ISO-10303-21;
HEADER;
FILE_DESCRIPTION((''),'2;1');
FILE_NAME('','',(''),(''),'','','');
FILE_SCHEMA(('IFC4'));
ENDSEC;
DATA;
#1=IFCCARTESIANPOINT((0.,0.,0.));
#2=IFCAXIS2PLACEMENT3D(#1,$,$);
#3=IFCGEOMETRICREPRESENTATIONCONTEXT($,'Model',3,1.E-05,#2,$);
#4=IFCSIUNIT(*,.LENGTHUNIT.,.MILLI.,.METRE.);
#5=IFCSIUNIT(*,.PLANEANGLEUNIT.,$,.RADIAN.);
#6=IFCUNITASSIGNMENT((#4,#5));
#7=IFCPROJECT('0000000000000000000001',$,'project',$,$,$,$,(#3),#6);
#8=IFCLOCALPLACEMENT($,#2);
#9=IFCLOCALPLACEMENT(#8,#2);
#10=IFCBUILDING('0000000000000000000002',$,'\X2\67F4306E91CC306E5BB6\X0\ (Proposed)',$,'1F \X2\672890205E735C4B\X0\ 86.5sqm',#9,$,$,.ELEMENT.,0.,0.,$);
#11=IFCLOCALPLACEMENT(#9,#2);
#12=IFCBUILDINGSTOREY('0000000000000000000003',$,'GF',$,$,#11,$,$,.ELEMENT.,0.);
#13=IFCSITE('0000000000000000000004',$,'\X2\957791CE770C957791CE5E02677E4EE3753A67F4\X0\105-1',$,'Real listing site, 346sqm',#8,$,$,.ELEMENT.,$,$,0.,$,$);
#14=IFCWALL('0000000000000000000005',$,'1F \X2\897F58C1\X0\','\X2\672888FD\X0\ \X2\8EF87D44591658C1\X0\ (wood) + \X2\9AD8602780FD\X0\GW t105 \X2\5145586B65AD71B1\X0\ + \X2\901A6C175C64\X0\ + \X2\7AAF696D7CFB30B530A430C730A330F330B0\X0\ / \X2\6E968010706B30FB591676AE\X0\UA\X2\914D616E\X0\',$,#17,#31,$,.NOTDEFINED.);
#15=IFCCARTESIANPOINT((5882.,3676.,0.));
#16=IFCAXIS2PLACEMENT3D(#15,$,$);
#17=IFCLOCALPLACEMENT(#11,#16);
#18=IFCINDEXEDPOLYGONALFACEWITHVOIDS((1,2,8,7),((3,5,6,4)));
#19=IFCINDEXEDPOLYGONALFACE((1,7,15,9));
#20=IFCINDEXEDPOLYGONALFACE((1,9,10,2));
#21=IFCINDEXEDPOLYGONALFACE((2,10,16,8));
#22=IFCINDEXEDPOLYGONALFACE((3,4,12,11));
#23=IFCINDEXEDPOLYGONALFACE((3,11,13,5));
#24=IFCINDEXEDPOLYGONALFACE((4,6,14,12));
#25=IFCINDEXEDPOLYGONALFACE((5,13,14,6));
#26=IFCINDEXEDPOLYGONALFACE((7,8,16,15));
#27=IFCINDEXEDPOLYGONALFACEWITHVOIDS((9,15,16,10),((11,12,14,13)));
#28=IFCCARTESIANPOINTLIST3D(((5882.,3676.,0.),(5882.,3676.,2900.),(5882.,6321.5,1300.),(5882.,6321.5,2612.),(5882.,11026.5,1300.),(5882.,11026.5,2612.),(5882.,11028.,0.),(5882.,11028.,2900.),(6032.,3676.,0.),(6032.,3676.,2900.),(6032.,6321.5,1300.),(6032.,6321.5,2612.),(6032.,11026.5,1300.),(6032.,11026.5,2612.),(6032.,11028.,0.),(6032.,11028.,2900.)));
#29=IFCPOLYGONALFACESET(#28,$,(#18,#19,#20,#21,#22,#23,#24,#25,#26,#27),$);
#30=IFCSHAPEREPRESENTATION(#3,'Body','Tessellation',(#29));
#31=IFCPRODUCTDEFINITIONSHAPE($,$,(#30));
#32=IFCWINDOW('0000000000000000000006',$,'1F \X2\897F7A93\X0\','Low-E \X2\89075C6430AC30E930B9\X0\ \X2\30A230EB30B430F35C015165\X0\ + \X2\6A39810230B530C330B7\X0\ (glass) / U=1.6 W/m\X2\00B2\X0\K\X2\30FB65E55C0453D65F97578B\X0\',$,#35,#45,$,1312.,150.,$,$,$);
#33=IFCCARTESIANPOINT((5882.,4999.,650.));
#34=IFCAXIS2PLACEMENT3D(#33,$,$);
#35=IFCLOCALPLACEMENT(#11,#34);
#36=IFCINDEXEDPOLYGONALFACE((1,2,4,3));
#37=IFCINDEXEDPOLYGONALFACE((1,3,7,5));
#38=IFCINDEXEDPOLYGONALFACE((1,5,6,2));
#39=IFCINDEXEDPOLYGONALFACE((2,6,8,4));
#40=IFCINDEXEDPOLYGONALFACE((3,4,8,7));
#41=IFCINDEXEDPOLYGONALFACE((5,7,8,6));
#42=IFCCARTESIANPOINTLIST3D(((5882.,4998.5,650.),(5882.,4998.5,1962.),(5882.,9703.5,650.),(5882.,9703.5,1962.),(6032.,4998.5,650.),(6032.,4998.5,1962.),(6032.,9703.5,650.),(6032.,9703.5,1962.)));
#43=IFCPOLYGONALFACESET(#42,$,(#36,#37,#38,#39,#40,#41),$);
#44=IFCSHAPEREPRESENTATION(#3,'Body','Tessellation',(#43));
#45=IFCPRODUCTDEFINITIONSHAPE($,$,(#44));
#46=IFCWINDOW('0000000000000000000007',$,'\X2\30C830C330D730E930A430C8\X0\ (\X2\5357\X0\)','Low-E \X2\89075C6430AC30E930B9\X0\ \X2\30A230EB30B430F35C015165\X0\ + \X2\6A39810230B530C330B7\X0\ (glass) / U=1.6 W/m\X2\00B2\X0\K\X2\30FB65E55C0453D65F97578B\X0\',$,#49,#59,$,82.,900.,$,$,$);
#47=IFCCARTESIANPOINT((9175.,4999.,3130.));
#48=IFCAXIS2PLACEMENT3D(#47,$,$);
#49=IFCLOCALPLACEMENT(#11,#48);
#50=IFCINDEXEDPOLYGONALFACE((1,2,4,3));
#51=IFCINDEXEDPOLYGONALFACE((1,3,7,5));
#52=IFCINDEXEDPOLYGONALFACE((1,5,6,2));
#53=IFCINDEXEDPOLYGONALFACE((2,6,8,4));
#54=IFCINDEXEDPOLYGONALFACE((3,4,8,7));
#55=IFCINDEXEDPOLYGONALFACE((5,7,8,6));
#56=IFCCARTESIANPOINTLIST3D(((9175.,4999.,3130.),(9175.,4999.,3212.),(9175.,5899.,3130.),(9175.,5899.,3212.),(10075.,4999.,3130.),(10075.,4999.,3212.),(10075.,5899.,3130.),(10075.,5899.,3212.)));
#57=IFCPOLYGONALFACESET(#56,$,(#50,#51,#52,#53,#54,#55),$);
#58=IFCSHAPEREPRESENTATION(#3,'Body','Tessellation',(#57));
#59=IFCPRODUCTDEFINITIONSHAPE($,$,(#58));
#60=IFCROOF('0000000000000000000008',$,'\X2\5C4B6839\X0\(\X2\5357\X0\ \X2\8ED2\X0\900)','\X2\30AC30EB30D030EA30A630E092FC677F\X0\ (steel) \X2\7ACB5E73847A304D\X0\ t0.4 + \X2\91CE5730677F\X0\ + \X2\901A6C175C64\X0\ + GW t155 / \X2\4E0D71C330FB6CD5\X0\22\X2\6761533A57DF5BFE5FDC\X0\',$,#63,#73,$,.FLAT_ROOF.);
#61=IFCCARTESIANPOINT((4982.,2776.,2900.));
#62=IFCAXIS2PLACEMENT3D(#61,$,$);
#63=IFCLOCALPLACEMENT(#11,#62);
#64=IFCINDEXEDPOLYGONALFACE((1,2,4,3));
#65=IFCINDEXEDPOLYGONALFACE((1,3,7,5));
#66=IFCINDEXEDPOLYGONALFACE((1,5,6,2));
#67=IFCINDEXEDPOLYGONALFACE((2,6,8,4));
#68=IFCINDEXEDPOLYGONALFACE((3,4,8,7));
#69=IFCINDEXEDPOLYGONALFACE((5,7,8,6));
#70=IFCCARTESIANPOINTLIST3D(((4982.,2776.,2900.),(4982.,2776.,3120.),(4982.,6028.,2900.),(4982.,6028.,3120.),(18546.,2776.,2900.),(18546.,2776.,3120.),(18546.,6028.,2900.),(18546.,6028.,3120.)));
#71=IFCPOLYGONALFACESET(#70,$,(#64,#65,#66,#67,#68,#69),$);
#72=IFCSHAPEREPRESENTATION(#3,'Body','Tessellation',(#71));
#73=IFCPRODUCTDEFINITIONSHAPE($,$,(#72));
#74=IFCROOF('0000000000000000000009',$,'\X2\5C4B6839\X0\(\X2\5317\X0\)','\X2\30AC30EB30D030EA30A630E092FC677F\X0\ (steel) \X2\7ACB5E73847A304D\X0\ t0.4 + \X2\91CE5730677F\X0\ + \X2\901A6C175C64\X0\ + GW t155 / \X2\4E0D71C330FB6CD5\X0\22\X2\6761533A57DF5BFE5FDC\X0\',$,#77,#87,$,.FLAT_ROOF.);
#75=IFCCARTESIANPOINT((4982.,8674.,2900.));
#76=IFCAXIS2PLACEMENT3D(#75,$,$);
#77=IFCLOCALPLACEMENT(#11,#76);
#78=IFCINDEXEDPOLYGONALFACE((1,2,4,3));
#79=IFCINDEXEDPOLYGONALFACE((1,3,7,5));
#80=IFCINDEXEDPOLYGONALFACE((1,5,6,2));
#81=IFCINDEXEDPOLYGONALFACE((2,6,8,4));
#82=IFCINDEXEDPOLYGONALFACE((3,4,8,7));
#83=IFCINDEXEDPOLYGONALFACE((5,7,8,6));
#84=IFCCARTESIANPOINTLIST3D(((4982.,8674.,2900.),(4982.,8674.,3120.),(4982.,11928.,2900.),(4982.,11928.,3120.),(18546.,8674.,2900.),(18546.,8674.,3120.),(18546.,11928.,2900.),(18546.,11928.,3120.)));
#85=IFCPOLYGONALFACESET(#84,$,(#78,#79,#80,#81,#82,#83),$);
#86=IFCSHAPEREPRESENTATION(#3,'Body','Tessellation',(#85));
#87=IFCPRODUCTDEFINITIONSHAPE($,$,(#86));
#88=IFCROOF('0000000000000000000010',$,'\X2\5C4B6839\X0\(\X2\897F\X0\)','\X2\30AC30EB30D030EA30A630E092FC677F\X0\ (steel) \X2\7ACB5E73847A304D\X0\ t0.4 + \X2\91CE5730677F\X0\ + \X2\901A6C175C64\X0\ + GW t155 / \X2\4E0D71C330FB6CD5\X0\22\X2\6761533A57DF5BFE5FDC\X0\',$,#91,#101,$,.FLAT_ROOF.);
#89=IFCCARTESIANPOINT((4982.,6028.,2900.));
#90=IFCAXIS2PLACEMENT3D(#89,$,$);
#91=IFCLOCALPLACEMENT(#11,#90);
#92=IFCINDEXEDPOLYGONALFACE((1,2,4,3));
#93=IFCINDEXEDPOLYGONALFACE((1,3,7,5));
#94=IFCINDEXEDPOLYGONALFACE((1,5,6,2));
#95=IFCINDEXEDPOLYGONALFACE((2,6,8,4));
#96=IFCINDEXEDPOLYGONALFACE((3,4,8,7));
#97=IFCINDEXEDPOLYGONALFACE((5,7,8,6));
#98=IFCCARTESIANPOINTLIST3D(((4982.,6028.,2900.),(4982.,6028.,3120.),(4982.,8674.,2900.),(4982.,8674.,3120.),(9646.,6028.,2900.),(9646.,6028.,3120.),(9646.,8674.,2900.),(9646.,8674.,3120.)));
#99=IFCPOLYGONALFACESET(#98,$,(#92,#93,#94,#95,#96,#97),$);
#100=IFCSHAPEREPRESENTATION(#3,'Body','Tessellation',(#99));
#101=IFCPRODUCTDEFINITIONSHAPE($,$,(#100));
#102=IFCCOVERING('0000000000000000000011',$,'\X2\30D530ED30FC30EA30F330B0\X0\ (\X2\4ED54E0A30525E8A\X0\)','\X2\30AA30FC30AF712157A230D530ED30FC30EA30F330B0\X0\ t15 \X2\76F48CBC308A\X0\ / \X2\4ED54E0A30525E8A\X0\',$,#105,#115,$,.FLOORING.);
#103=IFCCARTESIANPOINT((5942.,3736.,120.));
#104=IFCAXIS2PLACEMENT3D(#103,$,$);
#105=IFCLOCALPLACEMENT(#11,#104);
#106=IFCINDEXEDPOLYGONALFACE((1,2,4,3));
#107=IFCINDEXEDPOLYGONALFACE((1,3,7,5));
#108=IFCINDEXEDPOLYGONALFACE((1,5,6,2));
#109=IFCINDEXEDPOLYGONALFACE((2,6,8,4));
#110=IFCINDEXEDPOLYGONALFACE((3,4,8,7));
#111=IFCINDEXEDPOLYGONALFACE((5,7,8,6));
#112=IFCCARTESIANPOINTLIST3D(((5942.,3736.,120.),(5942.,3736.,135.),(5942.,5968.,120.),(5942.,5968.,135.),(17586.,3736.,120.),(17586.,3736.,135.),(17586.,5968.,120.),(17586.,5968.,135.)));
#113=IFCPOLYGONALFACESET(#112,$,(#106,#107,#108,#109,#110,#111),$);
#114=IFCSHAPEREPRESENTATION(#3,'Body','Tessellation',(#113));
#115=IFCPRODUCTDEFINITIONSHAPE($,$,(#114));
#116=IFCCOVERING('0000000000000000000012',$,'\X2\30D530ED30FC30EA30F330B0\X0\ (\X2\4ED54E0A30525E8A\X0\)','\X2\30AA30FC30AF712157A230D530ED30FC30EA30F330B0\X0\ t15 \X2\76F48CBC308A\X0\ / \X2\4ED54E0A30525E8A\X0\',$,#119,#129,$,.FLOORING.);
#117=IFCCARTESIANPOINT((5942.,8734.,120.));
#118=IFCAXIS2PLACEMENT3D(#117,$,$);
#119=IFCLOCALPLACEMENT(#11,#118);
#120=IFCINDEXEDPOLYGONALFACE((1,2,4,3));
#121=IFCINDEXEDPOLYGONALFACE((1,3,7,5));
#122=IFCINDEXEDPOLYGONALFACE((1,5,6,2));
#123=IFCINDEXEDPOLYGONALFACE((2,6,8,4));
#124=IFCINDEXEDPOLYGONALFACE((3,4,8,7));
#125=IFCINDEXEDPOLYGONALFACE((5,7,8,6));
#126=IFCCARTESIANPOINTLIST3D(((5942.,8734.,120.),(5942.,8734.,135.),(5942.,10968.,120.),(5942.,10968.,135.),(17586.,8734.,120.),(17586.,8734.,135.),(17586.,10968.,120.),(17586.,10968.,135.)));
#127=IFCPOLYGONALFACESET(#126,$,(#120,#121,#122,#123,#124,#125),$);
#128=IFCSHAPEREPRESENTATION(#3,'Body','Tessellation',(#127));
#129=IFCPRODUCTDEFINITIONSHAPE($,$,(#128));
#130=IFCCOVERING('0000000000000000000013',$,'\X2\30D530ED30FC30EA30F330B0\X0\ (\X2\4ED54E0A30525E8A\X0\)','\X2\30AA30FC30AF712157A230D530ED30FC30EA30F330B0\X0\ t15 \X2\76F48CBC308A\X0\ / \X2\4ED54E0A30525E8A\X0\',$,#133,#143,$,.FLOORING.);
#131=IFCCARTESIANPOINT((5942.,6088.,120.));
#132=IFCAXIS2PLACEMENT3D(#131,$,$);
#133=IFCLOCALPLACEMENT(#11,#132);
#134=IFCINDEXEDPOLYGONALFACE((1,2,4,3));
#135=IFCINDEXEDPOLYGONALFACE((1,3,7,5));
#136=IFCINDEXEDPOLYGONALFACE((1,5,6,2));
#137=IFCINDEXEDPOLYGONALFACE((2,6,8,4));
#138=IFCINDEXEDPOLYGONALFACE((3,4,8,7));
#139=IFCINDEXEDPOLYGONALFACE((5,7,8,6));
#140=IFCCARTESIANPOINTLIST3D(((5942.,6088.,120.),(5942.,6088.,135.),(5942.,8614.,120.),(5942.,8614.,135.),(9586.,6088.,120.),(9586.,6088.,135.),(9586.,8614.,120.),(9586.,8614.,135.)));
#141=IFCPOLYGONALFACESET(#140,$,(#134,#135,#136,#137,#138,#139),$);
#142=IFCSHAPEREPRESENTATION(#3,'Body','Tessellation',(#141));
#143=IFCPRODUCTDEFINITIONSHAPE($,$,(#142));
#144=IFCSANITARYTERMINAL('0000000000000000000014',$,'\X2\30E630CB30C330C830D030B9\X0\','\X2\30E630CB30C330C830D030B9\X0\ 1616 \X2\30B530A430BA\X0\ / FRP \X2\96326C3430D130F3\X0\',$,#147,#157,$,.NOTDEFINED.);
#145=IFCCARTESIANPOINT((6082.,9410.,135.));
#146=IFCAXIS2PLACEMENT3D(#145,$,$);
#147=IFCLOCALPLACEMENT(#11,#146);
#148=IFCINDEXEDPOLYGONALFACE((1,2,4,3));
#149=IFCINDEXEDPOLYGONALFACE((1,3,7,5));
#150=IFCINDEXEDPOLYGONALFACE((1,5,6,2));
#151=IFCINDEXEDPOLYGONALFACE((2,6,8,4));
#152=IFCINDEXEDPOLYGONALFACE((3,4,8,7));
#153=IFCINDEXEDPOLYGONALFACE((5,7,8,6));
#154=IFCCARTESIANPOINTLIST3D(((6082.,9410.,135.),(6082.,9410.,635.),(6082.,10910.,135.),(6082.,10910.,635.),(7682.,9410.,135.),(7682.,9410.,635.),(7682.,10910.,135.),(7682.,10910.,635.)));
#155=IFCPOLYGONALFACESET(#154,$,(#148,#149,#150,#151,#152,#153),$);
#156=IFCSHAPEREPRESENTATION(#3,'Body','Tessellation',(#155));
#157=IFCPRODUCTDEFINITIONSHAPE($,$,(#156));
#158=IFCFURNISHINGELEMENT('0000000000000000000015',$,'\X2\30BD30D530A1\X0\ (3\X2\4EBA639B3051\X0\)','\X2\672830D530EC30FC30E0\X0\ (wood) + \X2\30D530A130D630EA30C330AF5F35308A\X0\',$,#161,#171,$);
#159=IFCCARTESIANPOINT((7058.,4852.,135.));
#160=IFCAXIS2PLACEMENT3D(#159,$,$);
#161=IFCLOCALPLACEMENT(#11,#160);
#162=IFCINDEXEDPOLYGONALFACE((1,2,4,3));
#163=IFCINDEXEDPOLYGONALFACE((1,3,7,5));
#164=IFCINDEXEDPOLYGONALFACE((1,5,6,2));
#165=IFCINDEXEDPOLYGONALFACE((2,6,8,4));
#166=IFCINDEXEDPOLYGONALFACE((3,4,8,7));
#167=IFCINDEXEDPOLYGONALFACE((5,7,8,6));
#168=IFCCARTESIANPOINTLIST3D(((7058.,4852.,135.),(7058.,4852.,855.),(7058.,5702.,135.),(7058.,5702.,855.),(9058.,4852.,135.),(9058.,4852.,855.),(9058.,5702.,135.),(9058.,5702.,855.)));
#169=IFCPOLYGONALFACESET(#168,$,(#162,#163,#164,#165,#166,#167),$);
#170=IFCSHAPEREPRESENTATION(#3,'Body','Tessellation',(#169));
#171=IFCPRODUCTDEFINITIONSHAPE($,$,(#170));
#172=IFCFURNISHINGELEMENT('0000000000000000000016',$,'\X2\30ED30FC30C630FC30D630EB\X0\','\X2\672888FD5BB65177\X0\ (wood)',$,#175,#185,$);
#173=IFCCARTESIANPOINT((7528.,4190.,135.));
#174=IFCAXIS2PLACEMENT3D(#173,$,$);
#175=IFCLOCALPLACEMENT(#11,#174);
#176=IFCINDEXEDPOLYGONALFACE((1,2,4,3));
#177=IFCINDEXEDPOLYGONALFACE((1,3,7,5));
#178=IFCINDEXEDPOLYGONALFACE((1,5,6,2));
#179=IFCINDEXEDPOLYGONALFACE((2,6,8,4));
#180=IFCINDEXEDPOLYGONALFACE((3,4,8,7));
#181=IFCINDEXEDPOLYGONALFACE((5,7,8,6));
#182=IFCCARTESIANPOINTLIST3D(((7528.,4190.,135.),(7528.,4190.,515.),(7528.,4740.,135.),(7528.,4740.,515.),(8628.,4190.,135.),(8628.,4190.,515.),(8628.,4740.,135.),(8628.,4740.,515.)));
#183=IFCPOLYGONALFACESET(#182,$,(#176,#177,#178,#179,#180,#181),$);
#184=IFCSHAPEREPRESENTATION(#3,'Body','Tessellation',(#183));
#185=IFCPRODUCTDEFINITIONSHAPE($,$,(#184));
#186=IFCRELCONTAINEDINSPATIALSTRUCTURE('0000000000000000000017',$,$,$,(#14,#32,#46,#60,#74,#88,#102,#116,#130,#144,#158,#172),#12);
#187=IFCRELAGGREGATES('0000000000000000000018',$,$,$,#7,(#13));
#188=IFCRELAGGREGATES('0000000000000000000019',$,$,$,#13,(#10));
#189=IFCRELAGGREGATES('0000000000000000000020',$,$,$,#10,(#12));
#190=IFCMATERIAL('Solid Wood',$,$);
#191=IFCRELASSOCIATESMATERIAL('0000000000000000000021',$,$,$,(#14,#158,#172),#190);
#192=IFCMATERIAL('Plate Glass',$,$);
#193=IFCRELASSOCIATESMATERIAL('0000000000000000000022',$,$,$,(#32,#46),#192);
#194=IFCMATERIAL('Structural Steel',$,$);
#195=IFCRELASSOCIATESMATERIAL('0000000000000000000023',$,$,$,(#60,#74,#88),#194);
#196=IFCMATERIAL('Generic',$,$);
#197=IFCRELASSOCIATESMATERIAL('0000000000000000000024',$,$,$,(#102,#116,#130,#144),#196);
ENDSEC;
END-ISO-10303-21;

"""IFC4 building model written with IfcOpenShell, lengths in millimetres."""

from ifc_helpers import new_model, si_unit, frame, frame_2d, origin, place, context, project, spatial, rectangle, extrude, material, element, fill, save


model = new_model("IFC4")

# Units and contexts
model_context = context("Model", 3, precision=1e-05, world=origin())
ifc_project = project(units=[si_unit("LENGTHUNIT", "METRE", prefix="MILLI"), si_unit("PLANEANGLEUNIT", "RADIAN")], contexts=[model_context])

# Site, building, storey
site_placement = place(None, origin())
site = spatial("IfcSite", under=ifc_project, at=site_placement, Name="長野県長野市松代町柴105-1", ObjectType="Real listing site, 346sqm", CompositionType="ELEMENT", RefElevation=0.0)
building_placement = place(site_placement, origin())
building = spatial("IfcBuilding", under=site, at=building_placement, Name="柴の里の家 (Proposed)", ObjectType="1F 木造平屋 86.5sqm", CompositionType="ELEMENT", ElevationOfRefHeight=0.0, ElevationOfTerrain=0.0)
storey_placement = place(building_placement, origin())
storey = spatial("IfcBuildingStorey", under=building, at=storey_placement, Name="GF", CompositionType="ELEMENT", Elevation=0.0)

# Shared definitions
ifc_material_1 = material(Name="Solid Wood")

# Shared definitions
ifc_material_2 = material(Name="Plate Glass")

# Wall, opening, window
wall_1_placement = place(storey_placement, frame((5882.0, 3676.0, 0.0)))
wall_1 = element("IfcWall", 1, at=wall_1_placement, inside=storey, material=ifc_material_1, Name="1F 西壁", Description="木製 軸組外壁 (wood) + 高性能GW t105 充填断熱 + 通気層 + 窯業系サイディング / 準耐火・外皮UA配慮", PredefinedType="NOTDEFINED", context=model_context, shape_type="SweptSolid", body=[
    extrude(rectangle(XDim=150.0, YDim=7352.0, at=frame_2d((75.0, 3676.0))), frame((5882.0, 3676.0, 0.0)), (0.0, 0.0, 1.0), 2900.0),
])
opening_1_placement = place(storey_placement, frame((5882.0, 4999.0, 650.0)))
opening_1 = element("IfcOpeningElement", 2, at=opening_1_placement, cuts=wall_1, PredefinedType="NOTDEFINED", context=model_context, shape_type="SweptSolid", body=[
    extrude(rectangle(XDim=150.0, YDim=4705.0, at=frame_2d((75.0, 2352.0))), frame((5882.0, 4999.0, 650.0)), (0.0, 0.0, 1.0), 1312.0),
])
window_1_placement = place(storey_placement, frame((5882.0, 4999.0, 650.0)))
window_1 = element("IfcWindow", 3, at=window_1_placement, inside=storey, material=ifc_material_2, Name="1F 西窓", Description="Low-E 複層ガラス アルゴン封入 + 樹脂サッシ (glass) / U=1.6 W/m²K・日射取得型", OverallHeight=1312.0, OverallWidth=150.0, context=model_context, shape_type="SweptSolid", body=[
    extrude(rectangle(XDim=150.0, YDim=4705.0, at=frame_2d((75.0, 2352.0))), frame((5882.0, 4999.0, 650.0)), (0.0, 0.0, 1.0), 1312.0),
])
fill(opening_1, window_1)

# Window
window_2_placement = place(storey_placement, frame((9175.0, 4999.0, 3130.0)))
element("IfcWindow", 4, at=window_2_placement, inside=storey, material=ifc_material_2, Name="トップライト (南)", Description="Low-E 複層ガラス アルゴン封入 + 樹脂サッシ (glass) / U=1.6 W/m²K・日射取得型", OverallHeight=82.0, OverallWidth=900.0, context=model_context, shape_type="SweptSolid", body=[
    extrude(rectangle(XDim=900.0, YDim=900.0, at=frame_2d((450.0, 450.0))), frame((9175.0, 4999.0, 3130.0)), (0.0, 0.0, 1.0), 82.0),
])

# Roofs
ifc_material_3 = material(Name="Structural Steel")
roof_1_placement = place(storey_placement, frame((4982.0, 2776.0, 2900.0)))
element("IfcRoof", 5, at=roof_1_placement, inside=storey, material=ifc_material_3, Name="屋根(南 軒900)", Description="ガルバリウム鋼板 (steel) 立平葺き t0.4 + 野地板 + 通気層 + GW t155 / 不燃・法22条区域対応", PredefinedType="FLAT_ROOF", context=model_context, shape_type="SweptSolid", body=[
    extrude(rectangle(XDim=13564.0, YDim=3252.0, at=frame_2d((6782.0, 1626.0))), frame((4982.0, 2776.0, 2900.0)), (0.0, 0.0, 1.0), 220.0),
])
roof_2_placement = place(storey_placement, frame((4982.0, 8674.0, 2900.0)))
element("IfcRoof", 6, at=roof_2_placement, inside=storey, material=ifc_material_3, Name="屋根(北)", Description="ガルバリウム鋼板 (steel) 立平葺き t0.4 + 野地板 + 通気層 + GW t155 / 不燃・法22条区域対応", PredefinedType="FLAT_ROOF", context=model_context, shape_type="SweptSolid", body=[
    extrude(rectangle(XDim=13564.0, YDim=3254.0, at=frame_2d((6782.0, 1627.0))), frame((4982.0, 8674.0, 2900.0)), (0.0, 0.0, 1.0), 220.0),
])
roof_3_placement = place(storey_placement, frame((4982.0, 6028.0, 2900.0)))
element("IfcRoof", 7, at=roof_3_placement, inside=storey, material=ifc_material_3, Name="屋根(西)", Description="ガルバリウム鋼板 (steel) 立平葺き t0.4 + 野地板 + 通気層 + GW t155 / 不燃・法22条区域対応", PredefinedType="FLAT_ROOF", context=model_context, shape_type="SweptSolid", body=[
    extrude(rectangle(XDim=4664.0, YDim=2646.0, at=frame_2d((2332.0, 1323.0))), frame((4982.0, 6028.0, 2900.0)), (0.0, 0.0, 1.0), 220.0),
])

# Coverings
ifc_material_4 = material(Name="Generic")
covering_1_placement = place(storey_placement, frame((5942.0, 3736.0, 120.0)))
element("IfcCovering", 8, at=covering_1_placement, inside=storey, material=ifc_material_4, Name="フローリング (仕上げ床)", Description="オーク無垢フローリング t15 直貼り / 仕上げ床", PredefinedType="FLOORING", context=model_context, shape_type="SweptSolid", body=[
    extrude(rectangle(XDim=11644.0, YDim=2232.0, at=frame_2d((5822.0, 1116.0))), frame((5942.0, 3736.0, 120.0)), (0.0, 0.0, 1.0), 15.0),
])
covering_2_placement = place(storey_placement, frame((5942.0, 8734.0, 120.0)))
element("IfcCovering", 9, at=covering_2_placement, inside=storey, material=ifc_material_4, Name="フローリング (仕上げ床)", Description="オーク無垢フローリング t15 直貼り / 仕上げ床", PredefinedType="FLOORING", context=model_context, shape_type="SweptSolid", body=[
    extrude(rectangle(XDim=11644.0, YDim=2234.0, at=frame_2d((5822.0, 1117.0))), frame((5942.0, 8734.0, 120.0)), (0.0, 0.0, 1.0), 15.0),
])
covering_3_placement = place(storey_placement, frame((5942.0, 6088.0, 120.0)))
element("IfcCovering", 10, at=covering_3_placement, inside=storey, material=ifc_material_4, Name="フローリング (仕上げ床)", Description="オーク無垢フローリング t15 直貼り / 仕上げ床", PredefinedType="FLOORING", context=model_context, shape_type="SweptSolid", body=[
    extrude(rectangle(XDim=3644.0, YDim=2526.0, at=frame_2d((1822.0, 1263.0))), frame((5942.0, 6088.0, 120.0)), (0.0, 0.0, 1.0), 15.0),
])

# Sanitary terminal
sanitary_terminal_placement = place(storey_placement, frame((6082.0, 9410.0, 135.0)))
element("IfcSanitaryTerminal", 11, at=sanitary_terminal_placement, inside=storey, material=ifc_material_4, Name="ユニットバス", Description="ユニットバス 1616 サイズ / FRP 防水パン", PredefinedType="NOTDEFINED", context=model_context, shape_type="SweptSolid", body=[
    extrude(rectangle(XDim=1600.0, YDim=1500.0, at=frame_2d((800.0, 750.0))), frame((6082.0, 9410.0, 135.0)), (0.0, 0.0, 1.0), 500.0),
])

# Furnishing elements
furnishing_1_placement = place(storey_placement, frame((7058.0, 4852.0, 135.0)))
element("IfcFurnishingElement", 12, at=furnishing_1_placement, inside=storey, material=ifc_material_1, Name="ソファ (3人掛け)", Description="木フレーム (wood) + ファブリック張り", context=model_context, shape_type="SweptSolid", body=[
    extrude(rectangle(XDim=2000.0, YDim=850.0, at=frame_2d((1000.0, 425.0))), frame((7058.0, 4852.0, 135.0)), (0.0, 0.0, 1.0), 720.0),
])
furnishing_2_placement = place(storey_placement, frame((7528.0, 4190.0, 135.0)))
element("IfcFurnishingElement", 13, at=furnishing_2_placement, inside=storey, material=ifc_material_1, Name="ローテーブル", Description="木製家具 (wood)", context=model_context, shape_type="SweptSolid", body=[
    extrude(rectangle(XDim=1100.0, YDim=550.0, at=frame_2d((550.0, 275.0))), frame((7528.0, 4190.0, 135.0)), (0.0, 0.0, 1.0), 380.0),
])

save(model, "model.ifc")
